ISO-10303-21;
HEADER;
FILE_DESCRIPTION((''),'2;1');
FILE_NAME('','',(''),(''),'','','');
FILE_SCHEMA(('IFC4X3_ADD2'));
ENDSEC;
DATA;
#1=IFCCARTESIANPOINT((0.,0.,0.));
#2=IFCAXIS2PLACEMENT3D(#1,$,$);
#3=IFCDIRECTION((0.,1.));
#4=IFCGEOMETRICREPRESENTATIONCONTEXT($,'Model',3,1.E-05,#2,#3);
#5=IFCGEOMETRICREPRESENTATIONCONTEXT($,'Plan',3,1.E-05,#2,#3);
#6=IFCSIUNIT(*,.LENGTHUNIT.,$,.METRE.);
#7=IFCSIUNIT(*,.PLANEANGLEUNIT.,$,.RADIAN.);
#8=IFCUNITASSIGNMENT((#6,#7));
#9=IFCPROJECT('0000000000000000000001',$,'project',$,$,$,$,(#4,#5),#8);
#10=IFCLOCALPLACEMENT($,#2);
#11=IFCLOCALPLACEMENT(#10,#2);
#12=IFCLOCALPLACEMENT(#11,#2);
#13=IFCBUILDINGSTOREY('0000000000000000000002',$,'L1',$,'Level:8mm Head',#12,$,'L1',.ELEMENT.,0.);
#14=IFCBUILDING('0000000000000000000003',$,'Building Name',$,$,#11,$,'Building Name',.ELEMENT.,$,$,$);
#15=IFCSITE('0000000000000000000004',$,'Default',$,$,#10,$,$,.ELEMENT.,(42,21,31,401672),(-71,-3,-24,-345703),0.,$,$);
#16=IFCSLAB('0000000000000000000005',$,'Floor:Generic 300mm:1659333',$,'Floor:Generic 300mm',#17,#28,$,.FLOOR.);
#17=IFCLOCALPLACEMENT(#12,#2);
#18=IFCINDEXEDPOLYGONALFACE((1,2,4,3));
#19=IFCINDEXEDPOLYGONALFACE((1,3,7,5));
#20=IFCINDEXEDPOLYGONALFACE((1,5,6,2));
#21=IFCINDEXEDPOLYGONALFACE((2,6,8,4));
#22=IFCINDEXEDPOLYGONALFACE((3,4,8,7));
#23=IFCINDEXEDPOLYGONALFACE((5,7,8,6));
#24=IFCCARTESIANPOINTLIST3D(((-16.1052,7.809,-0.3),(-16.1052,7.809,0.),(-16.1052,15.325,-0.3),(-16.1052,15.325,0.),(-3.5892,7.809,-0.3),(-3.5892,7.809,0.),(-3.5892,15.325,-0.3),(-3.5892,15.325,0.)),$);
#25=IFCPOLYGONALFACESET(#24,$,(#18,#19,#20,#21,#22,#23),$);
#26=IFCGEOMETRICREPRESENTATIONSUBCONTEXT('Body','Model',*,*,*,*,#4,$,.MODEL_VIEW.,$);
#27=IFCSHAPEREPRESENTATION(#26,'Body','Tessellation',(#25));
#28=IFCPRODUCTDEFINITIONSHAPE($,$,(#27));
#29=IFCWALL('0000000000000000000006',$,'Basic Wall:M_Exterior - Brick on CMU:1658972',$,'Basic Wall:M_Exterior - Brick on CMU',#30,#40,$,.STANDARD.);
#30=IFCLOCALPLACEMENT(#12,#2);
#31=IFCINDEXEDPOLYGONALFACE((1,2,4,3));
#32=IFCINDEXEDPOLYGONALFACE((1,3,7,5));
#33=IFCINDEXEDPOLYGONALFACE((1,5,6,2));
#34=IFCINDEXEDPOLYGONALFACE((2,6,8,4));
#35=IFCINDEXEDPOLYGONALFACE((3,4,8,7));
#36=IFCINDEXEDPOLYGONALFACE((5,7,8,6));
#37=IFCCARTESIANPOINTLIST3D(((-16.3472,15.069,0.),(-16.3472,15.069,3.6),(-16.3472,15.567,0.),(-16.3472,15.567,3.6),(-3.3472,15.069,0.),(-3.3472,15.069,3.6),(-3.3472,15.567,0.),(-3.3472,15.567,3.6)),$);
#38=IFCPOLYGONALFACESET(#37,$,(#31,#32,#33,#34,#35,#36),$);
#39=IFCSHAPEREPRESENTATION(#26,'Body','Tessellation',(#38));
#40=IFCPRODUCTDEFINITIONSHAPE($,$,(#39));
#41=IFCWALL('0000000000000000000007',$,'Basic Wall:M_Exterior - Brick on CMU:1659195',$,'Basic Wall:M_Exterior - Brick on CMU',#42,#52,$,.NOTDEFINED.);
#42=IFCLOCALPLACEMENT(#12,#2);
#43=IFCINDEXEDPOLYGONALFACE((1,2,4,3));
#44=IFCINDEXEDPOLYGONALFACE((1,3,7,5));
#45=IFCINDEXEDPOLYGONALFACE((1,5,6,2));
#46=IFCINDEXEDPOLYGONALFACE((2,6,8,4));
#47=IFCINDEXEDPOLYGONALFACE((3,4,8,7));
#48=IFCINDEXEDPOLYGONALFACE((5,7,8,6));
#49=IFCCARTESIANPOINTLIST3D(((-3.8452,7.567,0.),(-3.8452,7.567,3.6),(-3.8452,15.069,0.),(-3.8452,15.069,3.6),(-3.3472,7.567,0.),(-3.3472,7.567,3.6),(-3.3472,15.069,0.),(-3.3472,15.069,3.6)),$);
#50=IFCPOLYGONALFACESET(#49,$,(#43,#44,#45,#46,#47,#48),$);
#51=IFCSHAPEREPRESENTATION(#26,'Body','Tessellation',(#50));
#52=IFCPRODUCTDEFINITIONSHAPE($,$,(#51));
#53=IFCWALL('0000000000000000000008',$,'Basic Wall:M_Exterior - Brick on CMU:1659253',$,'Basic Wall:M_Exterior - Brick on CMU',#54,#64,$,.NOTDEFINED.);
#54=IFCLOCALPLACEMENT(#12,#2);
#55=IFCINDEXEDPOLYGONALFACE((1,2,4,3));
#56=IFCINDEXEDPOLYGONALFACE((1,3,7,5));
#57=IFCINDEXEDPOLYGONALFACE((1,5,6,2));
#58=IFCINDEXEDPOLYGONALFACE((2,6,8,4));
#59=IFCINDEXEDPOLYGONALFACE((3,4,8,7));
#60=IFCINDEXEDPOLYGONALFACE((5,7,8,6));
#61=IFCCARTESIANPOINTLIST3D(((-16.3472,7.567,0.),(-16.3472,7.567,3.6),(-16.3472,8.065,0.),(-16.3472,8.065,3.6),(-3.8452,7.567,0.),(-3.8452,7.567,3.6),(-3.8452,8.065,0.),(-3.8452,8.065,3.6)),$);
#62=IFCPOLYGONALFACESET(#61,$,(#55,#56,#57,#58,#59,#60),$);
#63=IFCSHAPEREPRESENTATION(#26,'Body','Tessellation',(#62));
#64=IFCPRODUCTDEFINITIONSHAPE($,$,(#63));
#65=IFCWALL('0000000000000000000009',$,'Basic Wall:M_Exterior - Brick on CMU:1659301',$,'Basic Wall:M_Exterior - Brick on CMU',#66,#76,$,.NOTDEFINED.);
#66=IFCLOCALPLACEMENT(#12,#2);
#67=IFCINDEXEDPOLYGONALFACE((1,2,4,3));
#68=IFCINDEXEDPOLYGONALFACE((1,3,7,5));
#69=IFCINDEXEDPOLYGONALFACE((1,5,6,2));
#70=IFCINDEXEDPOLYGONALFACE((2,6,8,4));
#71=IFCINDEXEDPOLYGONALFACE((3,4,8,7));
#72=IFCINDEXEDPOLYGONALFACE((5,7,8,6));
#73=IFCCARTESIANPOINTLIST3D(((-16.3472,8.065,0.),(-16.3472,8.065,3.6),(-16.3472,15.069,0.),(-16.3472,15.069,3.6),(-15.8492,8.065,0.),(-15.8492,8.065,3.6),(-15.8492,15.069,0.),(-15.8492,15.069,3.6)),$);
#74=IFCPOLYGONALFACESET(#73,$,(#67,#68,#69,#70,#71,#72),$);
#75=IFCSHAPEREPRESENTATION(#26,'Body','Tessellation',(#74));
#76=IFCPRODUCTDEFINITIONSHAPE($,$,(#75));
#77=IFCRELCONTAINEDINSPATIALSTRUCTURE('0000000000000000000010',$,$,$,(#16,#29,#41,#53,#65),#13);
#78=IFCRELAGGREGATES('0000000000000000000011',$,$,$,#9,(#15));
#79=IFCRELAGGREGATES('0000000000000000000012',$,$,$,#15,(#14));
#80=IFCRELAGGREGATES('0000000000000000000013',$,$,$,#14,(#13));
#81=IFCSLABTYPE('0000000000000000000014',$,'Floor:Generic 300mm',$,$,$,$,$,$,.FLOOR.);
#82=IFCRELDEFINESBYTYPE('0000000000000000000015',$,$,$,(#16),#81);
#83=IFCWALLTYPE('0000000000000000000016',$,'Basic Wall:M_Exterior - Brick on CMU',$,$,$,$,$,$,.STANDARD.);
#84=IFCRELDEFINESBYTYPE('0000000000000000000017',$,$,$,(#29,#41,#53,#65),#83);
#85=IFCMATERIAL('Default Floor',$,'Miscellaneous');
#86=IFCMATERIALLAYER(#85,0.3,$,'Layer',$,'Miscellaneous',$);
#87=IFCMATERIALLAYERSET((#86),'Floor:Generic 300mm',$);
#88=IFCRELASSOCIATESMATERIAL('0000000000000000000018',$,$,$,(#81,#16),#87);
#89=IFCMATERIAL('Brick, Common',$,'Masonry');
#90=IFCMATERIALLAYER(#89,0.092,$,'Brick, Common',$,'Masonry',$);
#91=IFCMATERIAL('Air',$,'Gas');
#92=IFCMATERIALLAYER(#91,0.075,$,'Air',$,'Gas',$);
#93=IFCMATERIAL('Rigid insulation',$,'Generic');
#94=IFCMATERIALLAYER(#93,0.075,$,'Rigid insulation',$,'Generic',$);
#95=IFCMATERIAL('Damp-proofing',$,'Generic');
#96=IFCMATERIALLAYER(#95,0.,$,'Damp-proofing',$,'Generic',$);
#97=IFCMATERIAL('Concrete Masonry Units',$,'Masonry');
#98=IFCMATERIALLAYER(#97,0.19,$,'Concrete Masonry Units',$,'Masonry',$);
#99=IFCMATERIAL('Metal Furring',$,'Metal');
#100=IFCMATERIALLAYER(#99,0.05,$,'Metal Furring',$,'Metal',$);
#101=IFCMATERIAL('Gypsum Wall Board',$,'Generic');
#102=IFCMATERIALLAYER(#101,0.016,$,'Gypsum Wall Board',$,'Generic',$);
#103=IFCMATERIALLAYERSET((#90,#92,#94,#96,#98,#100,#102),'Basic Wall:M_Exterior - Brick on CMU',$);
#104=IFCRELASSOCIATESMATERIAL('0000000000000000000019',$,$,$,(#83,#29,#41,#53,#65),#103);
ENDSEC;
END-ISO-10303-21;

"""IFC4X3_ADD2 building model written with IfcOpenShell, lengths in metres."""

from ifc_helpers import new_model, si_unit, direction, frame, frame_2d, origin, place, context, subcontext, project, spatial, rectangle, extrude, material, layer, layer_set, layer_usage, type_object, element, save


model = new_model("IFC4X3_ADD2")

# Units and contexts
model_context = context("Model", 3, precision=1e-05, world=origin(), true_north=direction((0.0, 1.0)))
plan_context = context("Plan", 3, precision=1e-05, world=origin(), true_north=direction((0.0, 1.0)))
body_context = subcontext(model_context, "Body", "Model", "MODEL_VIEW")
ifc_project = project(units=[si_unit("LENGTHUNIT", "METRE"), si_unit("PLANEANGLEUNIT", "RADIAN")], contexts=[model_context, plan_context])

# Site, building, storey
site_placement = place(None, origin())
site = spatial("IfcSite", under=ifc_project, at=site_placement, Name="Default", CompositionType="ELEMENT", RefLatitude=(42, 21, 31, 401672), RefLongitude=(-71, -3, -24, -345703), RefElevation=0.0)
building_placement = place(site_placement, origin())
building = spatial("IfcBuilding", under=site, at=building_placement, Name="Building Name", LongName="Building Name", CompositionType="ELEMENT")
storey_placement = place(building_placement, origin())
storey = spatial("IfcBuildingStorey", under=building, at=storey_placement, Name="L1", ObjectType="Level:8mm Head", LongName="L1", CompositionType="ELEMENT", Elevation=0.0)

# Slab
ifc_material_1 = material(Name="Default Floor", Category="Miscellaneous")
ifc_layer_1 = layer(ifc_material_1, 0.3, Name="Layer", Category="Miscellaneous")
ifc_layer_set_1 = layer_set([ifc_layer_1], Name="Floor:Generic 300mm")
ifc_layer_usage_1 = layer_usage(ifc_layer_set_1, "AXIS3", "POSITIVE", 0.0)
slab_type = type_object("IfcSlabType", Name="Floor:Generic 300mm", PredefinedType="FLOOR", material=ifc_layer_set_1)
slab_1_placement = place(storey_placement, origin())
element("IfcSlab", 1, at=slab_1_placement, inside=storey, type_object=slab_type, material=ifc_layer_usage_1, Name="Floor:Generic 300mm:1659333", ObjectType="Floor:Generic 300mm", PredefinedType="FLOOR", context=body_context, shape_type="SweptSolid", body=[
    extrude(rectangle(XDim=7.516, YDim=12.516, at=frame_2d((0.0, 0.0), x_axis=(1.0, 0.0))), frame((-9.8472, 11.567, 0.0), z_axis=(0.0, 0.0, -1.0), x_axis=(0.0, 1.0, 0.0)), (0.0, 0.0, 1.0), 0.3),
])

# Walls
ifc_material_2 = material(Name="Brick, Common", Category="Masonry")
ifc_layer_2 = layer(ifc_material_2, 0.092, Name="Brick, Common", Category="Masonry")
ifc_material_3 = material(Name="Air", Category="Gas")
ifc_layer_3 = layer(ifc_material_3, 0.075, Name="Air", Category="Gas")
ifc_material_4 = material(Name="Rigid insulation", Category="Generic")
ifc_layer_4 = layer(ifc_material_4, 0.075, Name="Rigid insulation", Category="Generic")
ifc_material_5 = material(Name="Damp-proofing", Category="Generic")
ifc_layer_5 = layer(ifc_material_5, 0.0, Name="Damp-proofing", Category="Generic")
ifc_material_6 = material(Name="Concrete Masonry Units", Category="Masonry")
ifc_layer_6 = layer(ifc_material_6, 0.19, Name="Concrete Masonry Units", Category="Masonry")
ifc_material_7 = material(Name="Metal Furring", Category="Metal")
ifc_layer_7 = layer(ifc_material_7, 0.05, Name="Metal Furring", Category="Metal")
ifc_material_8 = material(Name="Gypsum Wall Board", Category="Generic")
ifc_layer_8 = layer(ifc_material_8, 0.016, Name="Gypsum Wall Board", Category="Generic")
ifc_layer_set_2 = layer_set([ifc_layer_2, ifc_layer_3, ifc_layer_4, ifc_layer_5, ifc_layer_6, ifc_layer_7, ifc_layer_8], Name="Basic Wall:M_Exterior - Brick on CMU")
wall_type = type_object("IfcWallType", Name="Basic Wall:M_Exterior - Brick on CMU", PredefinedType="STANDARD", material=ifc_layer_set_2)
wall_1_placement = place(storey_placement, frame((-16.3472, 15.318, 0.0)))
element("IfcWall", 2, at=wall_1_placement, inside=storey, type_object=wall_type, material=ifc_layer_set_2, Name="Basic Wall:M_Exterior - Brick on CMU:1658972", ObjectType="Basic Wall:M_Exterior - Brick on CMU", PredefinedType="STANDARD", context=body_context, shape_type="SweptSolid", body=[
    extrude(rectangle(XDim=13.0, YDim=0.498, at=frame_2d((6.5, 0.0), x_axis=(-1.0, 0.0))), origin(), (0.0, 0.0, 1.0), 3.6),
])
wall_2_placement = place(storey_placement, frame((-3.5962, 15.069, 0.0), z_axis=(0.0, 0.0, 1.0), x_axis=(0.0, -1.0, 0.0)))
element("IfcWall", 3, at=wall_2_placement, inside=storey, type_object=wall_type, material=ifc_layer_set_2, Name="Basic Wall:M_Exterior - Brick on CMU:1659195", ObjectType="Basic Wall:M_Exterior - Brick on CMU", PredefinedType="NOTDEFINED", context=body_context, shape_type="SweptSolid", body=[
    extrude(rectangle(XDim=7.502, YDim=0.498, at=frame_2d((3.751, 0.0), x_axis=(-1.0, 0.0))), origin(), (0.0, 0.0, 1.0), 3.6),
])
wall_3_placement = place(storey_placement, frame((-3.8452, 7.816, 0.0), z_axis=(0.0, 0.0, 1.0), x_axis=(-1.0, 0.0, 0.0)))
element("IfcWall", 4, at=wall_3_placement, inside=storey, type_object=wall_type, material=ifc_layer_set_2, Name="Basic Wall:M_Exterior - Brick on CMU:1659253", ObjectType="Basic Wall:M_Exterior - Brick on CMU", PredefinedType="NOTDEFINED", context=body_context, shape_type="SweptSolid", body=[
    extrude(rectangle(XDim=12.502, YDim=0.498, at=frame_2d((6.251, 0.0), x_axis=(-1.0, 0.0))), origin(), (0.0, 0.0, 1.0), 3.6),
])
wall_4_placement = place(storey_placement, frame((-16.0982, 8.065, 0.0), z_axis=(0.0, 0.0, 1.0), x_axis=(0.0, 1.0, 0.0)))
element("IfcWall", 5, at=wall_4_placement, inside=storey, type_object=wall_type, material=ifc_layer_set_2, Name="Basic Wall:M_Exterior - Brick on CMU:1659301", ObjectType="Basic Wall:M_Exterior - Brick on CMU", PredefinedType="NOTDEFINED", context=body_context, shape_type="SweptSolid", body=[
    extrude(rectangle(XDim=7.004, YDim=0.498, at=frame_2d((3.502, 0.0), x_axis=(-1.0, 0.0))), origin(), (0.0, 0.0, 1.0), 3.6),
])

save(model, "model.ifc")
